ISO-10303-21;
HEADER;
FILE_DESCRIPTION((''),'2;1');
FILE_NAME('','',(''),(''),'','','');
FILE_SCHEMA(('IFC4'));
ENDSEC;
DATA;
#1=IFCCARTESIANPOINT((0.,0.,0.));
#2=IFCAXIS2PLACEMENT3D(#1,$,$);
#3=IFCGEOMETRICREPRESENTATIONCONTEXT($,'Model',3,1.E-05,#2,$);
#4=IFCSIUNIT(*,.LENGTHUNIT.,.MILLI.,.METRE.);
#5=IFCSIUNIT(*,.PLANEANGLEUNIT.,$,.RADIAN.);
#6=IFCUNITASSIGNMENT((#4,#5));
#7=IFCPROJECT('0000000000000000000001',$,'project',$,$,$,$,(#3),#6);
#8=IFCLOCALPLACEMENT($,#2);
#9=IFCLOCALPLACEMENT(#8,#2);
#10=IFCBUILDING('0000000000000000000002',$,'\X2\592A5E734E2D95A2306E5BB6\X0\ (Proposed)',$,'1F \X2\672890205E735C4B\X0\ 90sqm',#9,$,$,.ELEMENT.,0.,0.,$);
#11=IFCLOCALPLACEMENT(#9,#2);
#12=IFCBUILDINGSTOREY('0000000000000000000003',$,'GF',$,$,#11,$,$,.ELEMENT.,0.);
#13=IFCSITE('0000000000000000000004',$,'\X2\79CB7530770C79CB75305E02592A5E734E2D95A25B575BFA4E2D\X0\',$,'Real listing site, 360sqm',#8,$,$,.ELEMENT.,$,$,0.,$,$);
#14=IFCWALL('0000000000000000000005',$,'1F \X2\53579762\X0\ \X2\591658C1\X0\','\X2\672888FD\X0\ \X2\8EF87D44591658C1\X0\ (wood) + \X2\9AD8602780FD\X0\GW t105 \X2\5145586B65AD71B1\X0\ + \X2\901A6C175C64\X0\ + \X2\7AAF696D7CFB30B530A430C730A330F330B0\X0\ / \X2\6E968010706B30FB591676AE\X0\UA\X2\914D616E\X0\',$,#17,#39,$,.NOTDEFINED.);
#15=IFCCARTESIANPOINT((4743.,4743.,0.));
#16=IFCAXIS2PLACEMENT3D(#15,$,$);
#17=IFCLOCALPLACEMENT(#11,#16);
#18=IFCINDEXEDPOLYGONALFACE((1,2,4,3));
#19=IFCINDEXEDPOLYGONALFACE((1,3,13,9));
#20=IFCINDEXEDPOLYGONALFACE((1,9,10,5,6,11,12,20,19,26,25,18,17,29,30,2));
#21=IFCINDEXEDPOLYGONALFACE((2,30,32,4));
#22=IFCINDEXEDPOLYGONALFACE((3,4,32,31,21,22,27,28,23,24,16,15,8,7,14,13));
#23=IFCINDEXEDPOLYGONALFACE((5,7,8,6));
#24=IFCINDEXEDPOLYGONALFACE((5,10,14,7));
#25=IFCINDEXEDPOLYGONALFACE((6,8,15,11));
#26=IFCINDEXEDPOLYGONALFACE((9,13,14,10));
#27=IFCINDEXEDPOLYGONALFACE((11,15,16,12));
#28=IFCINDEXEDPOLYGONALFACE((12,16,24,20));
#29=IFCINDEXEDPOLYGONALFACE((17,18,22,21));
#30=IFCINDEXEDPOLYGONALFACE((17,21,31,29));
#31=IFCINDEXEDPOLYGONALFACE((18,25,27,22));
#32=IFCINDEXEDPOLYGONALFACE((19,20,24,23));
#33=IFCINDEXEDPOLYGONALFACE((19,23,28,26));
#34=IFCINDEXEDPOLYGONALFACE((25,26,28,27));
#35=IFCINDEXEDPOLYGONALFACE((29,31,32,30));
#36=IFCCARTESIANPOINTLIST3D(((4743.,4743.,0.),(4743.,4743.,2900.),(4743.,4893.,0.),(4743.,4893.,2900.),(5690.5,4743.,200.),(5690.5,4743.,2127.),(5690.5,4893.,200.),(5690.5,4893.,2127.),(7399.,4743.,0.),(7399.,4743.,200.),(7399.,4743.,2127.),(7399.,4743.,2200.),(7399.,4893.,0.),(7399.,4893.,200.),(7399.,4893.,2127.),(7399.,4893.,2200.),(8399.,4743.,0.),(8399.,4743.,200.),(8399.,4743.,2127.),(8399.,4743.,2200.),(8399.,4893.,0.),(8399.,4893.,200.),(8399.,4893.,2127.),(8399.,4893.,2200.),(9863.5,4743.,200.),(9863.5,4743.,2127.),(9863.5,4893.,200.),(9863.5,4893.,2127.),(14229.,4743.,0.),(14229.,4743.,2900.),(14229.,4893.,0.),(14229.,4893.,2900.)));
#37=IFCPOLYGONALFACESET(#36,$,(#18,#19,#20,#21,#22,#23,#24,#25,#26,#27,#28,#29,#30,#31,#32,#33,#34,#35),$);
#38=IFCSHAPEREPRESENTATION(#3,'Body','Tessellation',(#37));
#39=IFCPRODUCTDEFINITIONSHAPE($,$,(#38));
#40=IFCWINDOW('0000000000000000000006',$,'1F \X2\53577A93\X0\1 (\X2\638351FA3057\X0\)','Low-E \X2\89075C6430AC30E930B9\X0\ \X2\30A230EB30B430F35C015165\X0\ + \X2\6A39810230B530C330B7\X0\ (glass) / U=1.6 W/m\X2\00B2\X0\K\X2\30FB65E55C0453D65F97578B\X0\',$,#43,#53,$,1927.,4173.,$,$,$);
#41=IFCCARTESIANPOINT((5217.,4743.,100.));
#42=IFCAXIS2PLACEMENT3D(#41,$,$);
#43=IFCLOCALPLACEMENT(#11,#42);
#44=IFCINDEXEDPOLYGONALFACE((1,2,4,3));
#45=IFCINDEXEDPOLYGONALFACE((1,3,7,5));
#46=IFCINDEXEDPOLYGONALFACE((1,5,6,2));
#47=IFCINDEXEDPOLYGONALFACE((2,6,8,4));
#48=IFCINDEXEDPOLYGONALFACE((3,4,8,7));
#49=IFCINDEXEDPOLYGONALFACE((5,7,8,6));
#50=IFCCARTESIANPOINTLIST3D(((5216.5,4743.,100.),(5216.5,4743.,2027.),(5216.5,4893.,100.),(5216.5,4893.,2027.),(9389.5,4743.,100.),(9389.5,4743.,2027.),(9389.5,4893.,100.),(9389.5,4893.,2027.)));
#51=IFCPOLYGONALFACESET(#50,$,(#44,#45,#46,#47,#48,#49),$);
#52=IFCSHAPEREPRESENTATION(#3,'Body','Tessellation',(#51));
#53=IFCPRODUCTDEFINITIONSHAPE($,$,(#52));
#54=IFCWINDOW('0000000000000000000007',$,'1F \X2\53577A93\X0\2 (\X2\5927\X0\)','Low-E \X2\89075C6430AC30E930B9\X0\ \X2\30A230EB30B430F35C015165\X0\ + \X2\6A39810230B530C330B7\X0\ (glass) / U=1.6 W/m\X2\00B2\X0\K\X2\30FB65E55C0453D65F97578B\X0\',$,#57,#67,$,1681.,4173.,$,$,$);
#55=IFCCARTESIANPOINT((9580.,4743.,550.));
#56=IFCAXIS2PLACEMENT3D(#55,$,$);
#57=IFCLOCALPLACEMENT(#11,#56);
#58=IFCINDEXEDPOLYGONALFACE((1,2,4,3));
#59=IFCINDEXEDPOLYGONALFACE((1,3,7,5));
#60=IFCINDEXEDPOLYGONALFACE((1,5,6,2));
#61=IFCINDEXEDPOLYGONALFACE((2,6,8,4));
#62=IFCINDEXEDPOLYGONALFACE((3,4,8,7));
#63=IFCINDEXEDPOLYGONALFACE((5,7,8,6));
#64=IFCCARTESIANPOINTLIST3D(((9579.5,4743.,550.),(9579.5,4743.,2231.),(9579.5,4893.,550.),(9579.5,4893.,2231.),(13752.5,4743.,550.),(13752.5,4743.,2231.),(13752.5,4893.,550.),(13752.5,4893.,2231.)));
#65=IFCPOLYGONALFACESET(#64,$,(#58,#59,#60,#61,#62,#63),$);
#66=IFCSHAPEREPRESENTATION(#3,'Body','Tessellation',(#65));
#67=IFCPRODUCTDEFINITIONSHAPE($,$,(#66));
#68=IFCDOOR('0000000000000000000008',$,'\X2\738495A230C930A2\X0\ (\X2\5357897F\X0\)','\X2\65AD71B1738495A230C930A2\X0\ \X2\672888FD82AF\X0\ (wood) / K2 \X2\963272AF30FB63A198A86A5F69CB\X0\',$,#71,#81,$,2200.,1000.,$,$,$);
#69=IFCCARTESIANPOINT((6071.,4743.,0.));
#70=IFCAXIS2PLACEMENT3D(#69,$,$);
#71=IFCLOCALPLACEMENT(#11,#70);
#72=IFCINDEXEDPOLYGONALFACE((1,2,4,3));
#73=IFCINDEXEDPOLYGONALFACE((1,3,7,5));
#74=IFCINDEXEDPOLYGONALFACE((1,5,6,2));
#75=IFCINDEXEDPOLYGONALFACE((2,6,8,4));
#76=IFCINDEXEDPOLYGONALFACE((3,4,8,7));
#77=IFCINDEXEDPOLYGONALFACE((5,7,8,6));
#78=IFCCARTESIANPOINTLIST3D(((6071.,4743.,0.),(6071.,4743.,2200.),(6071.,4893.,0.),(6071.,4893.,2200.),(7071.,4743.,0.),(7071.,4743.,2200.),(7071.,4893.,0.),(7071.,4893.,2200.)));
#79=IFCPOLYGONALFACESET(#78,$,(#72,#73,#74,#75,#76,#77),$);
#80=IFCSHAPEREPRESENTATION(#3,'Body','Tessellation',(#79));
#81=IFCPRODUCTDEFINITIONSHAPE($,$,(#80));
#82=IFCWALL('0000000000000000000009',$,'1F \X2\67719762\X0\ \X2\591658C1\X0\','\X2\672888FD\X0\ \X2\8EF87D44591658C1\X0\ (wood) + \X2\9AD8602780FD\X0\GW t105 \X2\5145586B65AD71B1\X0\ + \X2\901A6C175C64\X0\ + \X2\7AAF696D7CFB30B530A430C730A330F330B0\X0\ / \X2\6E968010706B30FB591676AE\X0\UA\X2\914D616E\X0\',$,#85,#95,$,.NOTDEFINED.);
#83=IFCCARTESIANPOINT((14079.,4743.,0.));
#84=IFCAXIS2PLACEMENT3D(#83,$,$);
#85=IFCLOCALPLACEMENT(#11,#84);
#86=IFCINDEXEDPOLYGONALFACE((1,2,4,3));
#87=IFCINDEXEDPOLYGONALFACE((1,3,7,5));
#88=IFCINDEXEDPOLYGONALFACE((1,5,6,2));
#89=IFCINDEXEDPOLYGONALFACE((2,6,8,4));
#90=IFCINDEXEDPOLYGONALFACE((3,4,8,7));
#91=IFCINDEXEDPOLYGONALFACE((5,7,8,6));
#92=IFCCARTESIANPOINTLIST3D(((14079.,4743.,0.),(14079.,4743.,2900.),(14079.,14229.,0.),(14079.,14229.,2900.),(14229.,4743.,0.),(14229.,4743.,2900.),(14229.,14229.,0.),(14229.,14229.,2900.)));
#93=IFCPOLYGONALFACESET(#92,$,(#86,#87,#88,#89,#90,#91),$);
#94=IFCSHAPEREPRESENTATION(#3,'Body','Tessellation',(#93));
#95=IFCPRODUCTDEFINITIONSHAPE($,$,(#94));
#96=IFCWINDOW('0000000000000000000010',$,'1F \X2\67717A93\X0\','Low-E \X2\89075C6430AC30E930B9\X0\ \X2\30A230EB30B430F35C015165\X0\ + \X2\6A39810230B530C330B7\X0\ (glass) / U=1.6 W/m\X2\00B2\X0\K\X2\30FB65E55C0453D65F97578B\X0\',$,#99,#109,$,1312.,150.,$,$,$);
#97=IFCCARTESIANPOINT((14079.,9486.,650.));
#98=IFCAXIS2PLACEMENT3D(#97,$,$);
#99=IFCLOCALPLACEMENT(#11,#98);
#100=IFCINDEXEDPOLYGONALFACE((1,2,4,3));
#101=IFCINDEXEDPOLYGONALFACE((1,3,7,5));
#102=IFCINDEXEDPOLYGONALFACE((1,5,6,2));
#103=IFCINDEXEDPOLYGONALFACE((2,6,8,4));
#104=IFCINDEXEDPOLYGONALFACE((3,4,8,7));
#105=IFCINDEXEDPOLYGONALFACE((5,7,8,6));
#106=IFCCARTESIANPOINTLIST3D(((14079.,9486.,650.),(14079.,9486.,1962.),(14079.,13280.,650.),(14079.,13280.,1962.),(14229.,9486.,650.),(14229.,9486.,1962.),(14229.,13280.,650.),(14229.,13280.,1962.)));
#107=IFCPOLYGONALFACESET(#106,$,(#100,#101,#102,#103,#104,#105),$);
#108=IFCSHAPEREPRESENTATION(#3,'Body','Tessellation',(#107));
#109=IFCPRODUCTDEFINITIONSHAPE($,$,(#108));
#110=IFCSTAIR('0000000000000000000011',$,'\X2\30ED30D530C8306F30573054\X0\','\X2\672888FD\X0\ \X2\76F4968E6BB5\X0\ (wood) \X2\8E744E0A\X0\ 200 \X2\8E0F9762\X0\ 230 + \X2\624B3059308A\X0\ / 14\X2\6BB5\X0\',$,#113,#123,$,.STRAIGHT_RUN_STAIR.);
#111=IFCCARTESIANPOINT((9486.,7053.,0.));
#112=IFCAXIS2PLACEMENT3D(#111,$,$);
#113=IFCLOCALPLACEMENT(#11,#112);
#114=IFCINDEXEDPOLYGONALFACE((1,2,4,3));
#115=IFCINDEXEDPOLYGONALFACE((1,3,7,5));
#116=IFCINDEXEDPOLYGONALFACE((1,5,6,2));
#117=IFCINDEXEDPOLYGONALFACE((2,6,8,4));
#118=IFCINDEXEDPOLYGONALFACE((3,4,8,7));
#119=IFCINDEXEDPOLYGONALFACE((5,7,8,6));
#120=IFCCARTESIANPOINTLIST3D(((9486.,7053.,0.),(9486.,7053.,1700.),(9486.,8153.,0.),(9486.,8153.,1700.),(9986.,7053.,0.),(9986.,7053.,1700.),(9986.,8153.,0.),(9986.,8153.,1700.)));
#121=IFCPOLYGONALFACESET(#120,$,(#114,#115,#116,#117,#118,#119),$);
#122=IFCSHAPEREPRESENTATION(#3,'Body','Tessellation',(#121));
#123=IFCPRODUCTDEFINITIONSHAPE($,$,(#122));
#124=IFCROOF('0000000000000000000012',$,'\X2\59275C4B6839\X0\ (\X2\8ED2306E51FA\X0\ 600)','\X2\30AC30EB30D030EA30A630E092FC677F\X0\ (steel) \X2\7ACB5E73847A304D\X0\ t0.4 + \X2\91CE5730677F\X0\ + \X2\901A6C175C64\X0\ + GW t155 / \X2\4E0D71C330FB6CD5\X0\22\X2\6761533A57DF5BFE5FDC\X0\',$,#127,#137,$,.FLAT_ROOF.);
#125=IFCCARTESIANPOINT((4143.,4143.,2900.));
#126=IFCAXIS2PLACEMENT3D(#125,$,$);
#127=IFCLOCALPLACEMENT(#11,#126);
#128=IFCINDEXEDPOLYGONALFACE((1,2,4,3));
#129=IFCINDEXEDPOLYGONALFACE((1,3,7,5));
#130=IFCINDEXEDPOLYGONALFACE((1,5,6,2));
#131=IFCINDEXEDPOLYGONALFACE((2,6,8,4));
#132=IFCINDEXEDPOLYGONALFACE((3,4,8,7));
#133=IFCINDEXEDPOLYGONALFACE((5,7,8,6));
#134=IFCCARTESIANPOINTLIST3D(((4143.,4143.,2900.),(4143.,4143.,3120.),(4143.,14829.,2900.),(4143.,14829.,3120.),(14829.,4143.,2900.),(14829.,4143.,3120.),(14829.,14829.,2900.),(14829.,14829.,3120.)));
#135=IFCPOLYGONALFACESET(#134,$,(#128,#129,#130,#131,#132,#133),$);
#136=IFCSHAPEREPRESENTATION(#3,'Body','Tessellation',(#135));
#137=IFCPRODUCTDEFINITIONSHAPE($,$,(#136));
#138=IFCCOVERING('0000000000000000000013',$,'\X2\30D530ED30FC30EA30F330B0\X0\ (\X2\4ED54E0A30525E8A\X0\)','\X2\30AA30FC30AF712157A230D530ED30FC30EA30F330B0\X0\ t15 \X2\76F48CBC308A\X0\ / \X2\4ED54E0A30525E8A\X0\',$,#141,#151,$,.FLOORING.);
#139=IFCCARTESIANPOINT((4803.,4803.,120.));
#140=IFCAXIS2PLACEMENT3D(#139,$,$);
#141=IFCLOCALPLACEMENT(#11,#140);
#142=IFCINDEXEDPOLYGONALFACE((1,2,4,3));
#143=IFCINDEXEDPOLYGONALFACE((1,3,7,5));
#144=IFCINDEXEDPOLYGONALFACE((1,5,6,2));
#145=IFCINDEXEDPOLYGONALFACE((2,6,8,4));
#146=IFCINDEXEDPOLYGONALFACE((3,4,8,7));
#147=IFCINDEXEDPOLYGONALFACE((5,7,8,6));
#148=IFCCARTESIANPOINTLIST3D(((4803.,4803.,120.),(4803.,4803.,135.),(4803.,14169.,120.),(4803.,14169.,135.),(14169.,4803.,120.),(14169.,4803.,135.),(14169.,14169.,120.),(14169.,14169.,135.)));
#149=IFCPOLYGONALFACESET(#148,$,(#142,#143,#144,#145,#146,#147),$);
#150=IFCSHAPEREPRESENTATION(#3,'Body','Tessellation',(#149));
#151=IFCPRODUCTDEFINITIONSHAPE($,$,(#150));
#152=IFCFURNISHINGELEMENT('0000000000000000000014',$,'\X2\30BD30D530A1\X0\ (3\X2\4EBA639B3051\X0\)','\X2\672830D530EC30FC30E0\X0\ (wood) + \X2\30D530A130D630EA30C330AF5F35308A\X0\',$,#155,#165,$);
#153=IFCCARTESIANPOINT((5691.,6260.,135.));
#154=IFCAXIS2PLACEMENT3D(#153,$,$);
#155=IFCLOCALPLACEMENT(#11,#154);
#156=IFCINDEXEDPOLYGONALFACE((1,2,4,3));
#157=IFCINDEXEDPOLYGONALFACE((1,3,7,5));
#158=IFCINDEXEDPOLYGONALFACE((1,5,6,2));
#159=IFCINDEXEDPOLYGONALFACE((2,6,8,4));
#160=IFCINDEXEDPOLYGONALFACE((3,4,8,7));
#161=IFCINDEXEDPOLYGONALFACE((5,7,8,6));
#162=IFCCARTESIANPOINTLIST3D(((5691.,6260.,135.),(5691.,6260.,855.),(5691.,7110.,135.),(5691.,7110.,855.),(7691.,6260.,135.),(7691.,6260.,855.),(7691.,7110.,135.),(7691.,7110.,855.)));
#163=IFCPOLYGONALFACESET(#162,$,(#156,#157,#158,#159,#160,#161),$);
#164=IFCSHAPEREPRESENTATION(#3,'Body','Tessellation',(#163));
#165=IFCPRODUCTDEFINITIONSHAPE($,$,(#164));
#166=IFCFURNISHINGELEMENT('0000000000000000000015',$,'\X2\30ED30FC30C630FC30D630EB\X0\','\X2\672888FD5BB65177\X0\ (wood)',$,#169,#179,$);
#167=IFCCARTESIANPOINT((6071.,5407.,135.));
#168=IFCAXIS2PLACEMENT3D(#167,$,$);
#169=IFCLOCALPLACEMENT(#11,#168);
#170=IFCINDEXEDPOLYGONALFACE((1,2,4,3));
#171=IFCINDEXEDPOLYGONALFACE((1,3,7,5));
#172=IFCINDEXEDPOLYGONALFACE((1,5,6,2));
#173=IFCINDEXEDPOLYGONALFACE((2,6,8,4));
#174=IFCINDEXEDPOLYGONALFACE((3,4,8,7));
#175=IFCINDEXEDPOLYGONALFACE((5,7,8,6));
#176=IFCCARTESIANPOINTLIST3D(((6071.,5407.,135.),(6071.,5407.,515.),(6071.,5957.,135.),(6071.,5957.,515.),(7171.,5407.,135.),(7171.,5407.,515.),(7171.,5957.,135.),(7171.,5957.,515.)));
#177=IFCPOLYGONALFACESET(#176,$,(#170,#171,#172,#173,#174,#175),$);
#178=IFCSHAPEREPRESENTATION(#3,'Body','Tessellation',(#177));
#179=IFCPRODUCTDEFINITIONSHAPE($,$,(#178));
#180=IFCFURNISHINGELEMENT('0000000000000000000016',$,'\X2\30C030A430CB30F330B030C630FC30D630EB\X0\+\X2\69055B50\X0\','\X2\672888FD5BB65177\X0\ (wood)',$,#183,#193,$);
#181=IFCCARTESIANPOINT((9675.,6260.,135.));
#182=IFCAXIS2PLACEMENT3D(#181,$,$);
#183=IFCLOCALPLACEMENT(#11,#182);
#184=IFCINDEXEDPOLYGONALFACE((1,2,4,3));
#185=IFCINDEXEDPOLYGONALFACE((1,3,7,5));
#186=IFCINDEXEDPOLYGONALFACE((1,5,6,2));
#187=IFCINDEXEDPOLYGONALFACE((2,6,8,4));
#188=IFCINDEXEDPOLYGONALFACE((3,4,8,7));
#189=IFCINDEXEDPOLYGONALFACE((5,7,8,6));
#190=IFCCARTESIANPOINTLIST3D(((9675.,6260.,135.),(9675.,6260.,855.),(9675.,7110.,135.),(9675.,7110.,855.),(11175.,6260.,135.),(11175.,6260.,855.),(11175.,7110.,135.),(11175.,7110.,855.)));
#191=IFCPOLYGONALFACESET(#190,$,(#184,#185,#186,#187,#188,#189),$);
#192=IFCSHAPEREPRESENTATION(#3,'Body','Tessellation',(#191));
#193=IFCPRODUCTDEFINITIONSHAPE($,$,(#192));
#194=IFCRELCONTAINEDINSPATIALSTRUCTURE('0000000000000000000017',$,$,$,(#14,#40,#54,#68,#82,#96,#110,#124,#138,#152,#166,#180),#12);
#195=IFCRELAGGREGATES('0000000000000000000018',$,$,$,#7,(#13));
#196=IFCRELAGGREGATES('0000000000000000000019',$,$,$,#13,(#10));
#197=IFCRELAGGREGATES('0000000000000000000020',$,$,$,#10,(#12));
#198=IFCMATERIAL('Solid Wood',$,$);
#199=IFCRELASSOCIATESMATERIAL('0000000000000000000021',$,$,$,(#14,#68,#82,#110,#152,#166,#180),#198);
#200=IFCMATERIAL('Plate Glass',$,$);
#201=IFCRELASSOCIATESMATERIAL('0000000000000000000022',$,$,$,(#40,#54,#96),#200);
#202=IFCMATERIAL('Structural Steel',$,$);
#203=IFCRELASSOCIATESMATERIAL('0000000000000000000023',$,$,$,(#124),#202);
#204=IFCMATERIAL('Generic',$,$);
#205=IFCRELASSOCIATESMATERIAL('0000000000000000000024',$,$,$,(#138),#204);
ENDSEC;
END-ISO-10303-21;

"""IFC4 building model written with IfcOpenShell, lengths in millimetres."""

from ifc_helpers import new_model, si_unit, frame, frame_2d, origin, place, context, project, spatial, rectangle, extrude, material, element, fill, save


model = new_model("IFC4")

# Units and contexts
model_context = context("Model", 3, precision=1e-05, world=origin())
ifc_project = project(units=[si_unit("LENGTHUNIT", "METRE", prefix="MILLI"), si_unit("PLANEANGLEUNIT", "RADIAN")], contexts=[model_context])

# Site, building, storey
site_placement = place(None, origin())
site = spatial("IfcSite", under=ifc_project, at=site_placement, Name="秋田県秋田市太平中関字寺中", ObjectType="Real listing site, 360sqm", CompositionType="ELEMENT", RefElevation=0.0)
building_placement = place(site_placement, origin())
building = spatial("IfcBuilding", under=site, at=building_placement, Name="太平中関の家 (Proposed)", ObjectType="1F 木造平屋 90sqm", CompositionType="ELEMENT", ElevationOfRefHeight=0.0, ElevationOfTerrain=0.0)
storey_placement = place(building_placement, origin())
storey = spatial("IfcBuildingStorey", under=building, at=storey_placement, Name="GF", CompositionType="ELEMENT", Elevation=0.0)

# Shared definitions
ifc_material_1 = material(Name="Solid Wood")

# Wall, openings, windows, door
wall_1_placement = place(storey_placement, frame((4743.0, 4743.0, 0.0)))
wall_1 = element("IfcWall", 1, at=wall_1_placement, inside=storey, material=ifc_material_1, Name="1F 南面 外壁", Description="木製 軸組外壁 (wood) + 高性能GW t105 充填断熱 + 通気層 + 窯業系サイディング / 準耐火・外皮UA配慮", PredefinedType="NOTDEFINED", context=model_context, shape_type="SweptSolid", body=[
    extrude(rectangle(XDim=9486.0, YDim=150.0, at=frame_2d((4743.0, 75.0))), frame((4743.0, 4743.0, 0.0)), (0.0, 0.0, 1.0), 2900.0),
])
opening_1_placement = place(storey_placement, frame((5217.0, 4743.0, 100.0)))
opening_1 = element("IfcOpeningElement", 2, at=opening_1_placement, cuts=wall_1, PredefinedType="NOTDEFINED", context=model_context, shape_type="SweptSolid", body=[
    extrude(rectangle(XDim=4173.0, YDim=150.0, at=frame_2d((2086.0, 75.0))), frame((5217.0, 4743.0, 100.0)), (0.0, 0.0, 1.0), 1927.0),
])
opening_2_placement = place(storey_placement, frame((9580.0, 4743.0, 550.0)))
opening_2 = element("IfcOpeningElement", 3, at=opening_2_placement, cuts=wall_1, PredefinedType="NOTDEFINED", context=model_context, shape_type="SweptSolid", body=[
    extrude(rectangle(XDim=4173.0, YDim=150.0, at=frame_2d((2086.0, 75.0))), frame((9580.0, 4743.0, 550.0)), (0.0, 0.0, 1.0), 1681.0),
])
opening_3_placement = place(storey_placement, frame((6071.0, 4743.0, 0.0)))
opening_3 = element("IfcOpeningElement", 4, at=opening_3_placement, cuts=wall_1, PredefinedType="NOTDEFINED", context=model_context, shape_type="SweptSolid", body=[
    extrude(rectangle(XDim=1000.0, YDim=150.0, at=frame_2d((500.0, 75.0))), frame((6071.0, 4743.0, 0.0)), (0.0, 0.0, 1.0), 2200.0),
])
ifc_material_2 = material(Name="Plate Glass")
window_1_placement = place(storey_placement, frame((5217.0, 4743.0, 100.0)))
window_1 = element("IfcWindow", 5, at=window_1_placement, inside=storey, material=ifc_material_2, Name="1F 南窓1 (掃出し)", Description="Low-E 複層ガラス アルゴン封入 + 樹脂サッシ (glass) / U=1.6 W/m²K・日射取得型", OverallHeight=1927.0, OverallWidth=4173.0, context=model_context, shape_type="SweptSolid", body=[
    extrude(rectangle(XDim=4173.0, YDim=150.0, at=frame_2d((2086.0, 75.0))), frame((5217.0, 4743.0, 100.0)), (0.0, 0.0, 1.0), 1927.0),
])
fill(opening_1, window_1)
window_2_placement = place(storey_placement, frame((9580.0, 4743.0, 550.0)))
window_2 = element("IfcWindow", 6, at=window_2_placement, inside=storey, material=ifc_material_2, Name="1F 南窓2 (大)", Description="Low-E 複層ガラス アルゴン封入 + 樹脂サッシ (glass) / U=1.6 W/m²K・日射取得型", OverallHeight=1681.0, OverallWidth=4173.0, context=model_context, shape_type="SweptSolid", body=[
    extrude(rectangle(XDim=4173.0, YDim=150.0, at=frame_2d((2086.0, 75.0))), frame((9580.0, 4743.0, 550.0)), (0.0, 0.0, 1.0), 1681.0),
])
fill(opening_2, window_2)
door_placement = place(storey_placement, frame((6071.0, 4743.0, 0.0)))
door = element("IfcDoor", 7, at=door_placement, inside=storey, material=ifc_material_1, Name="玄関ドア (南西)", Description="断熱玄関ドア 木製芯 (wood) / K2 防犯・採風機構", OverallHeight=2200.0, OverallWidth=1000.0, context=model_context, shape_type="SweptSolid", body=[
    extrude(rectangle(XDim=1000.0, YDim=150.0, at=frame_2d((500.0, 75.0))), frame((6071.0, 4743.0, 0.0)), (0.0, 0.0, 1.0), 2200.0),
])
fill(opening_3, door)

# Wall, opening, window
wall_2_placement = place(storey_placement, frame((14079.0, 4743.0, 0.0)))
wall_2 = element("IfcWall", 8, at=wall_2_placement, inside=storey, material=ifc_material_1, Name="1F 東面 外壁", Description="木製 軸組外壁 (wood) + 高性能GW t105 充填断熱 + 通気層 + 窯業系サイディング / 準耐火・外皮UA配慮", PredefinedType="NOTDEFINED", context=model_context, shape_type="SweptSolid", body=[
    extrude(rectangle(XDim=150.0, YDim=9486.0, at=frame_2d((75.0, 4743.0))), frame((14079.0, 4743.0, 0.0)), (0.0, 0.0, 1.0), 2900.0),
])
opening_4_placement = place(storey_placement, frame((14079.0, 9486.0, 650.0)))
opening_4 = element("IfcOpeningElement", 9, at=opening_4_placement, cuts=wall_2, PredefinedType="NOTDEFINED", context=model_context, shape_type="SweptSolid", body=[
    extrude(rectangle(XDim=150.0, YDim=3794.0, at=frame_2d((75.0, 1897.0))), frame((14079.0, 9486.0, 650.0)), (0.0, 0.0, 1.0), 1312.0),
])
window_3_placement = place(storey_placement, frame((14079.0, 9486.0, 650.0)))
window_3 = element("IfcWindow", 10, at=window_3_placement, inside=storey, material=ifc_material_2, Name="1F 東窓", Description="Low-E 複層ガラス アルゴン封入 + 樹脂サッシ (glass) / U=1.6 W/m²K・日射取得型", OverallHeight=1312.0, OverallWidth=150.0, context=model_context, shape_type="SweptSolid", body=[
    extrude(rectangle(XDim=150.0, YDim=3794.0, at=frame_2d((75.0, 1897.0))), frame((14079.0, 9486.0, 650.0)), (0.0, 0.0, 1.0), 1312.0),
])
fill(opening_4, window_3)

# Stair
stair_placement = place(storey_placement, frame((9486.0, 7053.0, 0.0)))
element("IfcStair", 11, at=stair_placement, inside=storey, material=ifc_material_1, Name="ロフトはしご", Description="木製 直階段 (wood) 蹴上 200 踏面 230 + 手すり / 14段", PredefinedType="STRAIGHT_RUN_STAIR", context=model_context, shape_type="SweptSolid", body=[
    extrude(rectangle(XDim=500.0, YDim=1100.0, at=frame_2d((250.0, 550.0))), frame((9486.0, 7053.0, 0.0)), (0.0, 0.0, 1.0), 1700.0),
])

# Roof
ifc_material_3 = material(Name="Structural Steel")
roof_placement = place(storey_placement, frame((4143.0, 4143.0, 2900.0)))
element("IfcRoof", 12, at=roof_placement, inside=storey, material=ifc_material_3, Name="大屋根 (軒の出 600)", Description="ガルバリウム鋼板 (steel) 立平葺き t0.4 + 野地板 + 通気層 + GW t155 / 不燃・法22条区域対応", PredefinedType="FLAT_ROOF", context=model_context, shape_type="SweptSolid", body=[
    extrude(rectangle(XDim=10686.0, YDim=10686.0, at=frame_2d((5343.0, 5343.0))), frame((4143.0, 4143.0, 2900.0)), (0.0, 0.0, 1.0), 220.0),
])

# Covering
ifc_material_4 = material(Name="Generic")
covering_placement = place(storey_placement, frame((4803.0, 4803.0, 120.0)))
element("IfcCovering", 13, at=covering_placement, inside=storey, material=ifc_material_4, Name="フローリング (仕上げ床)", Description="オーク無垢フローリング t15 直貼り / 仕上げ床", PredefinedType="FLOORING", context=model_context, shape_type="SweptSolid", body=[
    extrude(rectangle(XDim=9366.0, YDim=9366.0, at=frame_2d((4683.0, 4683.0))), frame((4803.0, 4803.0, 120.0)), (0.0, 0.0, 1.0), 15.0),
])

# Furnishing elements
furnishing_1_placement = place(storey_placement, frame((5691.0, 6260.0, 135.0)))
element("IfcFurnishingElement", 14, at=furnishing_1_placement, inside=storey, material=ifc_material_1, Name="ソファ (3人掛け)", Description="木フレーム (wood) + ファブリック張り", context=model_context, shape_type="SweptSolid", body=[
    extrude(rectangle(XDim=2000.0, YDim=850.0, at=frame_2d((1000.0, 425.0))), frame((5691.0, 6260.0, 135.0)), (0.0, 0.0, 1.0), 720.0),
])
furnishing_2_placement = place(storey_placement, frame((6071.0, 5407.0, 135.0)))
element("IfcFurnishingElement", 15, at=furnishing_2_placement, inside=storey, material=ifc_material_1, Name="ローテーブル", Description="木製家具 (wood)", context=model_context, shape_type="SweptSolid", body=[
    extrude(rectangle(XDim=1100.0, YDim=550.0, at=frame_2d((550.0, 275.0))), frame((6071.0, 5407.0, 135.0)), (0.0, 0.0, 1.0), 380.0),
])
furnishing_3_placement = place(storey_placement, frame((9675.0, 6260.0, 135.0)))
element("IfcFurnishingElement", 16, at=furnishing_3_placement, inside=storey, material=ifc_material_1, Name="ダイニングテーブル+椅子", Description="木製家具 (wood)", context=model_context, shape_type="SweptSolid", body=[
    extrude(rectangle(XDim=1500.0, YDim=850.0, at=frame_2d((750.0, 425.0))), frame((9675.0, 6260.0, 135.0)), (0.0, 0.0, 1.0), 720.0),
])

save(model, "model.ifc")
